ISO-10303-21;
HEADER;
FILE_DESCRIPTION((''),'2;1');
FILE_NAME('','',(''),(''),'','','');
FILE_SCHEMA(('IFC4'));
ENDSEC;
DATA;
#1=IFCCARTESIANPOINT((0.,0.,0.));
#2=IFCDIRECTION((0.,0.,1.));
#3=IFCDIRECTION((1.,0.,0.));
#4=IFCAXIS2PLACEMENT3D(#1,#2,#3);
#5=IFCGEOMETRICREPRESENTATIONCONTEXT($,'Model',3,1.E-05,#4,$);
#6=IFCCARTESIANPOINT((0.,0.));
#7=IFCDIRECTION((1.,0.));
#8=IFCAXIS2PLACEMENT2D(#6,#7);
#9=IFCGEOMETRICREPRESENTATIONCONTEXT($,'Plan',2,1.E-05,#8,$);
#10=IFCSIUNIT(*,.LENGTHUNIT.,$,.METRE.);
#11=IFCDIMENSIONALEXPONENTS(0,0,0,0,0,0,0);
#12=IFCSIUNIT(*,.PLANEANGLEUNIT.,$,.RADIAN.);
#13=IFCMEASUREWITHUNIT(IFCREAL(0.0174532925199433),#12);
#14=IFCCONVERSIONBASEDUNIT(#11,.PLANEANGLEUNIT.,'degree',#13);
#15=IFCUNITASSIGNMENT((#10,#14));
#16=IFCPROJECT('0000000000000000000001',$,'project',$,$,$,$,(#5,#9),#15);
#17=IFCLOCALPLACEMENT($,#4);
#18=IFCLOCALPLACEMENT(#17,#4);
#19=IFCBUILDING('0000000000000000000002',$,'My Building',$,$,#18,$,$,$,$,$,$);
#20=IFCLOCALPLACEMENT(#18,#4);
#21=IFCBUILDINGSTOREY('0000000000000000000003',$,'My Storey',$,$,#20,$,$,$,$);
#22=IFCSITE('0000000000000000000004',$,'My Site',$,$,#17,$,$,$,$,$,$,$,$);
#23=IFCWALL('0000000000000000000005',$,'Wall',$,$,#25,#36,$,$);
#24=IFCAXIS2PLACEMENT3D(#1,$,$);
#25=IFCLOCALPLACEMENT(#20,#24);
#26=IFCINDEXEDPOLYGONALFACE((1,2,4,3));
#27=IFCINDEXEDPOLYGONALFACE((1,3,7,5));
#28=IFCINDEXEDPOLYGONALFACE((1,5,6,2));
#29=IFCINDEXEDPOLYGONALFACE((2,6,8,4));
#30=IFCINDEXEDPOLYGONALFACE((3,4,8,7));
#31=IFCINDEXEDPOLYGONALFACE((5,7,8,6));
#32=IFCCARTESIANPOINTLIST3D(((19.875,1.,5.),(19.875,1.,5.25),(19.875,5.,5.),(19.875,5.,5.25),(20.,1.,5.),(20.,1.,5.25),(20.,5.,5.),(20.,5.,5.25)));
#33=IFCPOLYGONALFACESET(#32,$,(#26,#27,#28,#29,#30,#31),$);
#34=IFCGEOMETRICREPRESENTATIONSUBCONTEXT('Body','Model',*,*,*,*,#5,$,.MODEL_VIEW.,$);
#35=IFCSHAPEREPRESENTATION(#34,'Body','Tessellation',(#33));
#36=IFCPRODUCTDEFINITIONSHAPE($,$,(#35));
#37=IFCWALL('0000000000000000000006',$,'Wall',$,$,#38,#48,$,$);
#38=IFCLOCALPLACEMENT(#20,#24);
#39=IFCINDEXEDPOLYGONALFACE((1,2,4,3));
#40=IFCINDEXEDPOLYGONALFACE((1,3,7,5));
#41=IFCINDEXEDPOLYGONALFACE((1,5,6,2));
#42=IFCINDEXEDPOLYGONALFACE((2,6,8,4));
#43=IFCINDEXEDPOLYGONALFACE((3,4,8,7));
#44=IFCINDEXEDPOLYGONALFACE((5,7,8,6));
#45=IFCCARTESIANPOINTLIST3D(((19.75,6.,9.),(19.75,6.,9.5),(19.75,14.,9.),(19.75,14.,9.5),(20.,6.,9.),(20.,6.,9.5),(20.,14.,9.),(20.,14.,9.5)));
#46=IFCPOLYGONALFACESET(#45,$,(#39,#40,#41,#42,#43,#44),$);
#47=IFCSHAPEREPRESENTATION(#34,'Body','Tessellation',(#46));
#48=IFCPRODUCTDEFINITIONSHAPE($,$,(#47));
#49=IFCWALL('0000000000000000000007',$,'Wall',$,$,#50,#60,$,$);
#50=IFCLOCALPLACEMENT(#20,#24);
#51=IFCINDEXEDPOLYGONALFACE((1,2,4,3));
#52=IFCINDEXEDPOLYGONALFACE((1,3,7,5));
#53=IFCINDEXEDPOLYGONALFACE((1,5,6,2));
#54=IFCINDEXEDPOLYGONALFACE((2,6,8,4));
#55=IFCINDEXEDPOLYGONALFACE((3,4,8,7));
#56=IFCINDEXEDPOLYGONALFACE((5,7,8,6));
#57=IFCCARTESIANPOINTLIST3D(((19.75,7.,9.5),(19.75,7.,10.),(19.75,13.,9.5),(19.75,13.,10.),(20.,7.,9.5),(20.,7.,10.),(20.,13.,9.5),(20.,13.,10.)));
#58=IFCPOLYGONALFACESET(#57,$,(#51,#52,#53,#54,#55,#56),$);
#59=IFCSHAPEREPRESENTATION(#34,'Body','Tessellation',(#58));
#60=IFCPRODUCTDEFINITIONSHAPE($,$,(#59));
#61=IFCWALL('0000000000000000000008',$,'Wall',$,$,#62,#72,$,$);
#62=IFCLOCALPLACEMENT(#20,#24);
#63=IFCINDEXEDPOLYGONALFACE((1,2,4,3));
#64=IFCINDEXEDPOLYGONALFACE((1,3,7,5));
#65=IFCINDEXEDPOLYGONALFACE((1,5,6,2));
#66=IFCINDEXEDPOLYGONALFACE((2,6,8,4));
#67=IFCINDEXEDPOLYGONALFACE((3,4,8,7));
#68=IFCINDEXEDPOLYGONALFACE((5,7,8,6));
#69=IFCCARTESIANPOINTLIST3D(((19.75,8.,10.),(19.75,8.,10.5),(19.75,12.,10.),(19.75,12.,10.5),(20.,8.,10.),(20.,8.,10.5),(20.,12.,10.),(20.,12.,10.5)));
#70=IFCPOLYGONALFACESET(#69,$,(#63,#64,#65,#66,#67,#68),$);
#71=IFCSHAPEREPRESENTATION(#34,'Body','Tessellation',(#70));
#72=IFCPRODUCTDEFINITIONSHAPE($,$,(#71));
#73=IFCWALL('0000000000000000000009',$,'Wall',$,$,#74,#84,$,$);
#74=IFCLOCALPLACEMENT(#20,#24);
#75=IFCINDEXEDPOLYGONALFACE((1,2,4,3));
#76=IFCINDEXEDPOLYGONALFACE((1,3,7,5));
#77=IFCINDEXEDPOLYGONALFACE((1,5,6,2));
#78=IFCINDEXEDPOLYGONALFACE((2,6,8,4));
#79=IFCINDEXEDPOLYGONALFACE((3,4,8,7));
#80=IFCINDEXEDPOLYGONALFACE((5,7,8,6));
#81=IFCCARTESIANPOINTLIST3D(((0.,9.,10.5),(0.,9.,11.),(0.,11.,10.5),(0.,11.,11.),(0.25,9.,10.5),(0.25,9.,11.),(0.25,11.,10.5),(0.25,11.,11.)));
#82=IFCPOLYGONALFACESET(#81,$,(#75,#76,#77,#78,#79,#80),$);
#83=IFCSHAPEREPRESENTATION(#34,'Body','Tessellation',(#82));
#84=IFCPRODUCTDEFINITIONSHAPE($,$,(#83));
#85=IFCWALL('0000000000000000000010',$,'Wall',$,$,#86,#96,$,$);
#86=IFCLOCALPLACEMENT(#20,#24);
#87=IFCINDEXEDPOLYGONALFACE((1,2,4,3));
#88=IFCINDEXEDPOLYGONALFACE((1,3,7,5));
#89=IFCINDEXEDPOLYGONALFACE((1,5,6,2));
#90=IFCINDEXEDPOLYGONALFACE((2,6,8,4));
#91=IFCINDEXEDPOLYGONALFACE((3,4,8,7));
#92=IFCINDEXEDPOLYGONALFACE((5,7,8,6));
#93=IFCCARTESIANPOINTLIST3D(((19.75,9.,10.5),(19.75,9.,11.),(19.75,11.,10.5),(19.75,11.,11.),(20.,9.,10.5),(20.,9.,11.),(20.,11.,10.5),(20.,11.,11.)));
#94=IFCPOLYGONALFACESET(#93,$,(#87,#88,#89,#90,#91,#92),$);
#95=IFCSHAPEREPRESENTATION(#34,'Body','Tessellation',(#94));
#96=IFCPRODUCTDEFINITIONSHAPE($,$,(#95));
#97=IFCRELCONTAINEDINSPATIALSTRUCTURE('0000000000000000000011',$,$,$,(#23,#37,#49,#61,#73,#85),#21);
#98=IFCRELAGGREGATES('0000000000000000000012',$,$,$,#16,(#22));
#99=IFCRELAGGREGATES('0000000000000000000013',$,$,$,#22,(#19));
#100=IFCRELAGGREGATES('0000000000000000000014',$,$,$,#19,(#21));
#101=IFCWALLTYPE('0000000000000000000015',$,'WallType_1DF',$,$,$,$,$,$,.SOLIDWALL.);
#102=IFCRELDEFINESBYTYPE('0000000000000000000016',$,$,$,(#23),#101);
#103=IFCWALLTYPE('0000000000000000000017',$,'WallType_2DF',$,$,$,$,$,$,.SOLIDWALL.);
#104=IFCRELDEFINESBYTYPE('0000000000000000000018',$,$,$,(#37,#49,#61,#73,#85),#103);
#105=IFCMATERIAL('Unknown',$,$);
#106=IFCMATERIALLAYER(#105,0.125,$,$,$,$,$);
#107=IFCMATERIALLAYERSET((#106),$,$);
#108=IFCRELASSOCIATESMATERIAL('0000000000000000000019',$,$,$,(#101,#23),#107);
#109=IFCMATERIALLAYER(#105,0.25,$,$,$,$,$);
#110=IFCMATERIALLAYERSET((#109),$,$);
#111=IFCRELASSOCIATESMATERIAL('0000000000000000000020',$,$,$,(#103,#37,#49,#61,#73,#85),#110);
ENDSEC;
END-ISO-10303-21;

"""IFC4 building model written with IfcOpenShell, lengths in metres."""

from ifc_helpers import new_model, entity, si_unit, converted_unit, frame, origin_with_axes, origin_2d_with_axis, place, context, subcontext, project, spatial, indexed_curve, outline, extrude, material, layer, layer_set, layer_usage, type_object, element, save


model = new_model("IFC4")

# Units and contexts
model_context = context("Model", 3, precision=1e-05, world=origin_with_axes())
plan_context = context("Plan", 2, precision=1e-05, world=origin_2d_with_axis())
body_context_1 = subcontext(model_context, "Body", "Model", "MODEL_VIEW")
ifc_project = project(units=[si_unit("LENGTHUNIT", "METRE"), converted_unit("PLANEANGLEUNIT", "degree", entity("IfcReal", 0.0174532925199433), si_unit("PLANEANGLEUNIT", "RADIAN"), dimensions=[0, 0, 0, 0, 0, 0, 0])], contexts=[model_context, plan_context])

# Site, building, storey
site_placement = place(None, origin_with_axes())
site = spatial("IfcSite", under=ifc_project, at=site_placement, Name="My Site")
building_placement = place(site_placement, origin_with_axes())
building = spatial("IfcBuilding", under=site, at=building_placement, Name="My Building")
storey_placement = place(building_placement, origin_with_axes())
storey = spatial("IfcBuildingStorey", under=building, at=storey_placement, Name="My Storey")

# Shared definitions
ifc_material = material(Name="Unknown")

# Shared definitions
ifc_layer_1 = layer(ifc_material, 0.125)
ifc_layer_set_1 = layer_set([ifc_layer_1])
wall_type_1 = type_object("IfcWallType", Name="WallType_1DF", PredefinedType="SOLIDWALL", material=ifc_layer_set_1)

# Wall
ifc_layer_usage_1 = layer_usage(ifc_layer_set_1, "AXIS2", "POSITIVE", 0.0)
wall_1_placement = place(storey_placement, frame((20.0, 1.0, 5.0), z_axis=(0.0, 0.0, 1.0), x_axis=(0.0, 1.0, 0.0)))
element("IfcWall", 1, at=wall_1_placement, inside=storey, type_object=wall_type_1, material=ifc_layer_usage_1, Name="Wall", context=body_context_1, shape_type="SweptSolid", body=[
    extrude(outline(indexed_curve([(0.0, 0.0), (0.0, 0.125), (4.0, 0.125), (4.0, 0.0), (0.0, 0.0)], self_intersect=False)), origin_with_axes(), (0.0, 0.0, 1.0), 0.25),
])

# Shared definitions
ifc_layer_2 = layer(ifc_material, 0.25)
ifc_layer_set_2 = layer_set([ifc_layer_2])
wall_type_2 = type_object("IfcWallType", Name="WallType_2DF", PredefinedType="SOLIDWALL", material=ifc_layer_set_2)

# Walls
ifc_layer_usage_2 = layer_usage(ifc_layer_set_2, "AXIS2", "POSITIVE", 0.0)
wall_2_placement = place(storey_placement, frame((20.0, 6.0, 9.0), z_axis=(0.0, 0.0, 1.0), x_axis=(0.0, 1.0, 0.0)))
element("IfcWall", 2, at=wall_2_placement, inside=storey, type_object=wall_type_2, material=ifc_layer_usage_2, Name="Wall", context=body_context_1, shape_type="SweptSolid", body=[
    extrude(outline(indexed_curve([(0.0, 0.0), (0.0, 0.25), (8.0, 0.25), (8.0, 0.0), (0.0, 0.0)], self_intersect=False)), origin_with_axes(), (0.0, 0.0, 1.0), 0.5),
])
ifc_layer_usage_3 = layer_usage(ifc_layer_set_2, "AXIS2", "POSITIVE", 0.0)
wall_3_placement = place(storey_placement, frame((20.0, 7.0, 9.5), z_axis=(0.0, 0.0, 1.0), x_axis=(0.0, 1.0, 0.0)))
element("IfcWall", 3, at=wall_3_placement, inside=storey, type_object=wall_type_2, material=ifc_layer_usage_3, Name="Wall", context=body_context_1, shape_type="SweptSolid", body=[
    extrude(outline(indexed_curve([(0.0, 0.0), (0.0, 0.25), (6.0, 0.25), (6.0, 0.0), (0.0, 0.0)], self_intersect=False)), origin_with_axes(), (0.0, 0.0, 1.0), 0.5),
])
ifc_layer_usage_4 = layer_usage(ifc_layer_set_2, "AXIS2", "POSITIVE", 0.0)
wall_4_placement = place(storey_placement, frame((20.0, 8.0, 10.0), z_axis=(0.0, 0.0, 1.0), x_axis=(0.0, 1.0, 0.0)))
element("IfcWall", 4, at=wall_4_placement, inside=storey, type_object=wall_type_2, material=ifc_layer_usage_4, Name="Wall", context=body_context_1, shape_type="SweptSolid", body=[
    extrude(outline(indexed_curve([(0.0, 0.0), (0.0, 0.25), (4.0, 0.25), (4.0, 0.0), (0.0, 0.0)], self_intersect=False)), origin_with_axes(), (0.0, 0.0, 1.0), 0.5),
])
ifc_layer_usage_5 = layer_usage(ifc_layer_set_2, "AXIS2", "POSITIVE", 0.0)
wall_5_placement = place(storey_placement, frame((0.25, 9.0, 10.5), z_axis=(0.0, 0.0, 1.0), x_axis=(0.0, 1.0, 0.0)))
element("IfcWall", 5, at=wall_5_placement, inside=storey, type_object=wall_type_2, material=ifc_layer_usage_5, Name="Wall", context=body_context_1, shape_type="SweptSolid", body=[
    extrude(outline(indexed_curve([(0.0, 0.0), (0.0, 0.25), (2.0, 0.25), (2.0, 0.0), (0.0, 0.0)], self_intersect=False)), origin_with_axes(), (0.0, 0.0, 1.0), 0.5),
])
ifc_layer_usage_6 = layer_usage(ifc_layer_set_2, "AXIS2", "POSITIVE", 0.0)
wall_6_placement = place(storey_placement, frame((20.0, 9.0, 10.5), z_axis=(0.0, 0.0, 1.0), x_axis=(0.0, 1.0, 0.0)))
element("IfcWall", 6, at=wall_6_placement, inside=storey, type_object=wall_type_2, material=ifc_layer_usage_6, Name="Wall", context=body_context_1, shape_type="SweptSolid", body=[
    extrude(outline(indexed_curve([(0.0, 0.0), (0.0, 0.25), (2.0, 0.25), (2.0, 0.0), (0.0, 0.0)], self_intersect=False)), origin_with_axes(), (0.0, 0.0, 1.0), 0.5),
])

save(model, "model.ifc")
